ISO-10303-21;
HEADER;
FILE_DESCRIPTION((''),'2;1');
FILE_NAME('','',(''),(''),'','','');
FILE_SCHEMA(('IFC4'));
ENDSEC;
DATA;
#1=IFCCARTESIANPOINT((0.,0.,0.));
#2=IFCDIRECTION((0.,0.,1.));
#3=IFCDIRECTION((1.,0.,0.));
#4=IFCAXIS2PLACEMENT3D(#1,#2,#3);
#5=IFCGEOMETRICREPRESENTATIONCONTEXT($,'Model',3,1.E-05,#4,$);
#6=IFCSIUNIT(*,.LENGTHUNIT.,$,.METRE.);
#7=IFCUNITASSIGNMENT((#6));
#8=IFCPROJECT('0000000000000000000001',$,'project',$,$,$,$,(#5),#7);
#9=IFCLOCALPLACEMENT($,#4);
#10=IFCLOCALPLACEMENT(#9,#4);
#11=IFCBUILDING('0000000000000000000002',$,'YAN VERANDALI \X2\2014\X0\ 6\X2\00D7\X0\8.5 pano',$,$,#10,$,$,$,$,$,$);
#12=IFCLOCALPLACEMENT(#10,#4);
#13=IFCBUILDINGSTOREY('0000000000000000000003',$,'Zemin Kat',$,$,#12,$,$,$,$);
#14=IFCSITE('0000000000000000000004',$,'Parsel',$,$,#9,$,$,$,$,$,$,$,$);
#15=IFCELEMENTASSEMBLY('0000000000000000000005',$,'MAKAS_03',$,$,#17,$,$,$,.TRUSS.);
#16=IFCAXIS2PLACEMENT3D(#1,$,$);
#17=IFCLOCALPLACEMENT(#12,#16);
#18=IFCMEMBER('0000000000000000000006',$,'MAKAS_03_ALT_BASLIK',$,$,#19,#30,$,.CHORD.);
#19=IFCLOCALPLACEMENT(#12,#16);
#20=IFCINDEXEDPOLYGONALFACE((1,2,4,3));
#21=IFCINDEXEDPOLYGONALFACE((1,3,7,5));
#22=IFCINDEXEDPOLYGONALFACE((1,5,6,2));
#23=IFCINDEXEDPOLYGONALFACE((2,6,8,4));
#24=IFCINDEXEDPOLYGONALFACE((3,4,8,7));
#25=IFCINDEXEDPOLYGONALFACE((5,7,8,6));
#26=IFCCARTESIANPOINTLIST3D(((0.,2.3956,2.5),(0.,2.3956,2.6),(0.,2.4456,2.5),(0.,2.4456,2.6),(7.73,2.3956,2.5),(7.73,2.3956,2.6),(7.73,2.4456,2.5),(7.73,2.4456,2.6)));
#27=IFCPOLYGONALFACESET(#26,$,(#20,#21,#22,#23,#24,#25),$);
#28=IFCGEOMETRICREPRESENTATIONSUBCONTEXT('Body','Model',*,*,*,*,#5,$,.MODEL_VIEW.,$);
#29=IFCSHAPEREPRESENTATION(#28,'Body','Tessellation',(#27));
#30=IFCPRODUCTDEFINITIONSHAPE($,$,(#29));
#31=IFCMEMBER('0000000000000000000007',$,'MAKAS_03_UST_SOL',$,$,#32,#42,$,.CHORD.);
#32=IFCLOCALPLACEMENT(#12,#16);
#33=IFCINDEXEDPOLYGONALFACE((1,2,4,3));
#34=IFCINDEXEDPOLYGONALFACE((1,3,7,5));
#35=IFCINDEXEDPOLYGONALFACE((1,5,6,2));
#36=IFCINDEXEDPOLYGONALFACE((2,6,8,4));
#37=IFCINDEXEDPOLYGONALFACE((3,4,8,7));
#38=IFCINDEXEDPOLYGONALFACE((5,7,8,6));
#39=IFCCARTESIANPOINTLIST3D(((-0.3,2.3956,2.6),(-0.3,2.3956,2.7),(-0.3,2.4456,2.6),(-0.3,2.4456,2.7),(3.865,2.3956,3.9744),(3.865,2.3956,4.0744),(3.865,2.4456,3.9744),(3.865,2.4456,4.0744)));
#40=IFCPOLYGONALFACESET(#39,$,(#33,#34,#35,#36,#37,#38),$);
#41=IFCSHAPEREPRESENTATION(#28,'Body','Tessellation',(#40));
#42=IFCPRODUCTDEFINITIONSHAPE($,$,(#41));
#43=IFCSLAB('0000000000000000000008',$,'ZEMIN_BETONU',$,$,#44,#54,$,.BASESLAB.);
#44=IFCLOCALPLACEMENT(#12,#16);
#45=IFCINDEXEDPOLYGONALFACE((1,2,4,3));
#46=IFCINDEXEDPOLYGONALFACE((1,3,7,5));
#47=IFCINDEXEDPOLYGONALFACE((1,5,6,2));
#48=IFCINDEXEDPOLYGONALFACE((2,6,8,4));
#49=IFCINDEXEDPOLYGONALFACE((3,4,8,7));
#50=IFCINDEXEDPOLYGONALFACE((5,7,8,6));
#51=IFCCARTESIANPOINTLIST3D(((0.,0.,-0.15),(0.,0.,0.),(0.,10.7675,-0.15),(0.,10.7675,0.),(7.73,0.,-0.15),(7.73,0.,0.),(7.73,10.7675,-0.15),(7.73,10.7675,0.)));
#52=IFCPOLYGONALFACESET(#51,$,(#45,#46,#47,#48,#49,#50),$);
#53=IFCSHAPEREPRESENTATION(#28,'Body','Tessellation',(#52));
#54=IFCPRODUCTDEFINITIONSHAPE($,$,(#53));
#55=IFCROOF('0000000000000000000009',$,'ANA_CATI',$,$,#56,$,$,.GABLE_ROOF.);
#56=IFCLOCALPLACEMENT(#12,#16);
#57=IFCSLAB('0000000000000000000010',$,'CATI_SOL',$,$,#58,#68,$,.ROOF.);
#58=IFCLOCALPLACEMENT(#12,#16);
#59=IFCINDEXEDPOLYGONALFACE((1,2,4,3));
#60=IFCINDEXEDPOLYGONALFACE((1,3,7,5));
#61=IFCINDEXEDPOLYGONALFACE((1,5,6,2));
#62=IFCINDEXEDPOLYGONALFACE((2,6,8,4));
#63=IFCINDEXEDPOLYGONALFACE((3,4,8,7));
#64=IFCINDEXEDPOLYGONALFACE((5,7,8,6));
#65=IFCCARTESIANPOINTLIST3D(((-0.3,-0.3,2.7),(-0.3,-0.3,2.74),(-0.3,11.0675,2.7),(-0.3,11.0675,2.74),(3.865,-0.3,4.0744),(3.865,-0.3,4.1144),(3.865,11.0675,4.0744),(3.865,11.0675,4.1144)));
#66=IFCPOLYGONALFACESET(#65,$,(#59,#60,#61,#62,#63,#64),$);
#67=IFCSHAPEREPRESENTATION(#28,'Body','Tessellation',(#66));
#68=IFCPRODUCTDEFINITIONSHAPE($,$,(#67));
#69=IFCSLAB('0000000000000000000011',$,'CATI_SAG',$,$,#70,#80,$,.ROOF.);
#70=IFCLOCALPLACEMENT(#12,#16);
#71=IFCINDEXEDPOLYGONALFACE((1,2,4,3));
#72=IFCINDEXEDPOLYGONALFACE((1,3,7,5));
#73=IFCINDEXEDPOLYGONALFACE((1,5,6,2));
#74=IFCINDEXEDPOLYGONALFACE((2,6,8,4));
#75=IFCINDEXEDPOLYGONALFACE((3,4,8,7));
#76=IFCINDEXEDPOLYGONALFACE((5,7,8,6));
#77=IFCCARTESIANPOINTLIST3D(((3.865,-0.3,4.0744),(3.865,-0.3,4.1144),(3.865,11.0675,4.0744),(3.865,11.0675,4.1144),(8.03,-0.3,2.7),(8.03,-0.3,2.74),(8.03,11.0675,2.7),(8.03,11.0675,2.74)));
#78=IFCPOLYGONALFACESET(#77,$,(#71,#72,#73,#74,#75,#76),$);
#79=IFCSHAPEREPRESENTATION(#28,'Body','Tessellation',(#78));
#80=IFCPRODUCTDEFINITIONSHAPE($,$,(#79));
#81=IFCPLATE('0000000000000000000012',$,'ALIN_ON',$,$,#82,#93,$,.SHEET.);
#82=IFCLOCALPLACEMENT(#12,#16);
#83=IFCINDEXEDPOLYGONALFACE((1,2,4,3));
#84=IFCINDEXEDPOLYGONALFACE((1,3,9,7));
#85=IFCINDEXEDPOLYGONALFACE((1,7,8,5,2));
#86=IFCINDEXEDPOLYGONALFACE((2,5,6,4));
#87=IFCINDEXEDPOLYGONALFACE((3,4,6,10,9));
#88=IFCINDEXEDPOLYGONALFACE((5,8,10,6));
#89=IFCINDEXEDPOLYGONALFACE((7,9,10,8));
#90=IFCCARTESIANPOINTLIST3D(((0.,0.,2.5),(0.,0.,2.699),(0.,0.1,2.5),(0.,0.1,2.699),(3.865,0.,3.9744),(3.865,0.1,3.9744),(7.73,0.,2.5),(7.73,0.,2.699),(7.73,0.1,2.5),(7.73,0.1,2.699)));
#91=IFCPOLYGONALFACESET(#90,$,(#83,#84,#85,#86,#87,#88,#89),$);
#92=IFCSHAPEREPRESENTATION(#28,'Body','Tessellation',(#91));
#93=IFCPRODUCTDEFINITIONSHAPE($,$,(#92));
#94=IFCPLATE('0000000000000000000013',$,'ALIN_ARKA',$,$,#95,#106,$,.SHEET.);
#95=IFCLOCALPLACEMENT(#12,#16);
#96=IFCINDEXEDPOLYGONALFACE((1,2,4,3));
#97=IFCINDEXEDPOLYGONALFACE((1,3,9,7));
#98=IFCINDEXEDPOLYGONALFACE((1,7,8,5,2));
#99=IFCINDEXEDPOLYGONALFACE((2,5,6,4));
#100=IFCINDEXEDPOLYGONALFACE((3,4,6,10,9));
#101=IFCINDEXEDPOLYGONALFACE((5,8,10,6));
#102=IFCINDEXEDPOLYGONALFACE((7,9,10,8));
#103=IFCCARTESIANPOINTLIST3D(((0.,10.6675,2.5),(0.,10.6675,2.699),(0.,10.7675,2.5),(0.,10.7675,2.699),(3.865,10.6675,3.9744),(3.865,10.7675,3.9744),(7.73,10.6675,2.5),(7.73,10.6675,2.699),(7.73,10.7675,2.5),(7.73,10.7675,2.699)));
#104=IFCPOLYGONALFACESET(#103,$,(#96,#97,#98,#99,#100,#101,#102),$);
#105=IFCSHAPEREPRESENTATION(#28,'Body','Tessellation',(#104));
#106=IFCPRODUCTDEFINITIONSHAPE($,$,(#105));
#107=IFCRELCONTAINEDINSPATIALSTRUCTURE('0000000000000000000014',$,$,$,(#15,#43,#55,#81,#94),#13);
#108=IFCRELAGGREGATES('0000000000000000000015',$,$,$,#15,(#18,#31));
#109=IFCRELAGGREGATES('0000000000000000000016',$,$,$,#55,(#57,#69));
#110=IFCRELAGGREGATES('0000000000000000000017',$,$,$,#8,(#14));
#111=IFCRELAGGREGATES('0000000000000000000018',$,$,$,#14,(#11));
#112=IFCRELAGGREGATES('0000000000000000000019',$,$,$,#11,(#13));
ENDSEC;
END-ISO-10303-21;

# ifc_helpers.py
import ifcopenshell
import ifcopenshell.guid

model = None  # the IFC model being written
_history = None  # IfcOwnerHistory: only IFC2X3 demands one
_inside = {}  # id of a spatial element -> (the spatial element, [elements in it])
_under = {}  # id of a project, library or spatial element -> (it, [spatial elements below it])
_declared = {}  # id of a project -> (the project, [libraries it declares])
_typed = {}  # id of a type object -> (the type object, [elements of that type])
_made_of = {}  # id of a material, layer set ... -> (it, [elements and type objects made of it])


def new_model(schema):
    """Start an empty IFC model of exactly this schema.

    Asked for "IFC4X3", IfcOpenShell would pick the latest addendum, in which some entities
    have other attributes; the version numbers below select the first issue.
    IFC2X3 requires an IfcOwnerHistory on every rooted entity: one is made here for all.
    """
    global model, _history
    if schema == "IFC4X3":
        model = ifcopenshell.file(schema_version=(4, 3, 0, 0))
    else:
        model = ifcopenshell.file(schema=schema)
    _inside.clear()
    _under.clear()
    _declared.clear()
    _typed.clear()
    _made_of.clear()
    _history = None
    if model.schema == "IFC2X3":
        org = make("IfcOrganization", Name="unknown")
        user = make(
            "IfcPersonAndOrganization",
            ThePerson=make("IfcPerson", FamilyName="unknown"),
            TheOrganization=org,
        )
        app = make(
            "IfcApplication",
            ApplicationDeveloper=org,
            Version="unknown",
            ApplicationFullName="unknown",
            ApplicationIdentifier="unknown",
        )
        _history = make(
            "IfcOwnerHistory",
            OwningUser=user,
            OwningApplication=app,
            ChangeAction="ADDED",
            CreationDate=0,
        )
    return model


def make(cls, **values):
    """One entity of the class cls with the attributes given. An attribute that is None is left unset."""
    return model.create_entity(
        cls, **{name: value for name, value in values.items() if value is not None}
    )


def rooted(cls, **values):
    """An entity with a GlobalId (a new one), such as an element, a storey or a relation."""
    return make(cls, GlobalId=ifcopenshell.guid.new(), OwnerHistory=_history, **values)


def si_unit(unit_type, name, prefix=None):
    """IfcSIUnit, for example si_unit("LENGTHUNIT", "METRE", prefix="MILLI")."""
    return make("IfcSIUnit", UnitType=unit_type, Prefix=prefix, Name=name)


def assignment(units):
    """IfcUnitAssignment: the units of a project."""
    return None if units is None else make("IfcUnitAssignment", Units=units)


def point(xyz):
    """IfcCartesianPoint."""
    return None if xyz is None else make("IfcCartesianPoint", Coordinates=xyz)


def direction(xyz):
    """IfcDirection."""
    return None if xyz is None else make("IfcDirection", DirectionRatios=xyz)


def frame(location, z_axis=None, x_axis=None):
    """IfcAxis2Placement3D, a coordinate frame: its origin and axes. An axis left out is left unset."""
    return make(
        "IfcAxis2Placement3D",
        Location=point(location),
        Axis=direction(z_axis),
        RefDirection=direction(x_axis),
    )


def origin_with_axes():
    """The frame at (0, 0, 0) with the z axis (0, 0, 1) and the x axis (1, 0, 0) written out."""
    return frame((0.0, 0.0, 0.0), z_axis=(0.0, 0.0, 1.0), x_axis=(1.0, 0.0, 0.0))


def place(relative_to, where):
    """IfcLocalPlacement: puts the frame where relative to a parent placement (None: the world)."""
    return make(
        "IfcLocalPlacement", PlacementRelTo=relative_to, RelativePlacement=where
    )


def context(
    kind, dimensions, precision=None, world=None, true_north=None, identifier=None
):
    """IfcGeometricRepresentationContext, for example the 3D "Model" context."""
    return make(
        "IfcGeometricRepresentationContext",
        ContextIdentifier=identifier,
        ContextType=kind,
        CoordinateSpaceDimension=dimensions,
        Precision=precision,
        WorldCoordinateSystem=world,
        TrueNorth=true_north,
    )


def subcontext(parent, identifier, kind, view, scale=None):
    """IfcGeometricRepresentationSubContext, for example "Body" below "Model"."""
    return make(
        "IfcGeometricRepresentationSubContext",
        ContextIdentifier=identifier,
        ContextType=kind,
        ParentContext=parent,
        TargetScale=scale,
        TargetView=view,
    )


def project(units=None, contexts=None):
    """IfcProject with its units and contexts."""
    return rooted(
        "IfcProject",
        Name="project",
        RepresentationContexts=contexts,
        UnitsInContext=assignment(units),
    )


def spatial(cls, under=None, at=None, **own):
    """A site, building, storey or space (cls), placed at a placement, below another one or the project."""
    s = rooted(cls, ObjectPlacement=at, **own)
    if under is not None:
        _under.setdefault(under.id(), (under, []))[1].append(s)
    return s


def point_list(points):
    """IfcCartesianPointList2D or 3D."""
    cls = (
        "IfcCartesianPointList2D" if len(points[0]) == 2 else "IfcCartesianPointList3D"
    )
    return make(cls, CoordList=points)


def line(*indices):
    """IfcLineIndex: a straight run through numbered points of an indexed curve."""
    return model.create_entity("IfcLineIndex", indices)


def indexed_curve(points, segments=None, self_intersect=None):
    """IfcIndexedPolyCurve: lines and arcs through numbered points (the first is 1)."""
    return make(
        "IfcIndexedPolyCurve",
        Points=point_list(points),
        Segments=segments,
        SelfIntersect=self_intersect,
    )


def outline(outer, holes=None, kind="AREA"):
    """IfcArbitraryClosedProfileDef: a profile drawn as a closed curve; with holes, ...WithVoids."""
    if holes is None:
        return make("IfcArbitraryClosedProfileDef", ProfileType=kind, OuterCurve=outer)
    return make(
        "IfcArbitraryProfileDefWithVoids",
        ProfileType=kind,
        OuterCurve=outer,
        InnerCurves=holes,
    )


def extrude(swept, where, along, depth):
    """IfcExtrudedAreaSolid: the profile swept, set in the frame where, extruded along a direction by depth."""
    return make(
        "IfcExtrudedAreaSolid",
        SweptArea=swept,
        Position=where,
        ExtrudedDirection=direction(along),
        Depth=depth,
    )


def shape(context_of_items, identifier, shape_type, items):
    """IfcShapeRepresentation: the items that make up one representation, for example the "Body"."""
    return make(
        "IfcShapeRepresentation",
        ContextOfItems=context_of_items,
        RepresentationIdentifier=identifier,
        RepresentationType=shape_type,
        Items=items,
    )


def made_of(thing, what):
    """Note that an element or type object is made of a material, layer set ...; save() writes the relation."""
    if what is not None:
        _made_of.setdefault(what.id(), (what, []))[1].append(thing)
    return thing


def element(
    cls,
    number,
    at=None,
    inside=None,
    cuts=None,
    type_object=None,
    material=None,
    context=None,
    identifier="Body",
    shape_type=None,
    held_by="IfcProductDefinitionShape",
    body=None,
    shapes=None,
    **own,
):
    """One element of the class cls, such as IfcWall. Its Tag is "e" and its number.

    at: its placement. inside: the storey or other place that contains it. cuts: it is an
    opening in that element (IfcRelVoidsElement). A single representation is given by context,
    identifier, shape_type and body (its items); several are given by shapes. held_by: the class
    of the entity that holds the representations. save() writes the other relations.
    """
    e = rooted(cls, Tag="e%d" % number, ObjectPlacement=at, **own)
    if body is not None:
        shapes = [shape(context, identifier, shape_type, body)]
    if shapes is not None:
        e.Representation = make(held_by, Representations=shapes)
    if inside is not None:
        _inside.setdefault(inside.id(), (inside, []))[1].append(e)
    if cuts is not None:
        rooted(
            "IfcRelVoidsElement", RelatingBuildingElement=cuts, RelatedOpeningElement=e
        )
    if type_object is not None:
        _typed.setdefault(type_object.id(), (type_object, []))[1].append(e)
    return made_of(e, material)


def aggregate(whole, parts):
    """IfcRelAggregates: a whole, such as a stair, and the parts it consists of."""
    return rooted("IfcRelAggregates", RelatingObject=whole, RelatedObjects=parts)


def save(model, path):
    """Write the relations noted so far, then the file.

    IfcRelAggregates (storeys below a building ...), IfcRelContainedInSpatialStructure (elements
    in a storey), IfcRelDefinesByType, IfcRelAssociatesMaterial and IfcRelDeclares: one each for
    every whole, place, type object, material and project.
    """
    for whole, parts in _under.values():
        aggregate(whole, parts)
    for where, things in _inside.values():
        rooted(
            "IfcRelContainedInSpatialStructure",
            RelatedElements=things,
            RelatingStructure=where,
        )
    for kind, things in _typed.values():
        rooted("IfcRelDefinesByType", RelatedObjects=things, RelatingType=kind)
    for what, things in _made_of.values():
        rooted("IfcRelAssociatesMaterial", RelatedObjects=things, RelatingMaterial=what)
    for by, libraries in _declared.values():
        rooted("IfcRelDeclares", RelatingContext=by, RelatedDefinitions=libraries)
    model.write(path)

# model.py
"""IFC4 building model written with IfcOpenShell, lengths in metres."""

from ifc_helpers import new_model, si_unit, frame, origin_with_axes, place, context, subcontext, project, spatial, line, indexed_curve, outline, extrude, element, aggregate, save


model = new_model("IFC4")

# Units and contexts
model_context = context("Model", 3, precision=1e-05, world=origin_with_axes())
body_context = subcontext(model_context, "Body", "Model", "MODEL_VIEW")
ifc_project = project(units=[si_unit("LENGTHUNIT", "METRE")], contexts=[model_context])

# Site, building, storey
site_placement = place(None, origin_with_axes())
site = spatial("IfcSite", under=ifc_project, at=site_placement, Name="Parsel")
building_placement = place(site_placement, origin_with_axes())
building = spatial("IfcBuilding", under=site, at=building_placement, Name="YAN VERANDALI — 6×8.5 pano")
storey_placement = place(building_placement, origin_with_axes())
storey = spatial("IfcBuildingStorey", under=building, at=storey_placement, Name="Zemin Kat")

# Element assembly, members
assembly_1_placement = place(storey_placement, origin_with_axes())
assembly_1 = element("IfcElementAssembly", 1, at=assembly_1_placement, inside=storey, Name="MAKAS_03", PredefinedType="TRUSS")
member_1_placement = place(assembly_1_placement, origin_with_axes())
member_1 = element("IfcMember", 2, at=member_1_placement, Name="MAKAS_03_ALT_BASLIK", PredefinedType="CHORD", context=body_context, shape_type="SweptSolid", body=[
    extrude(outline(indexed_curve([(0.0, 2.5), (7.73, 2.5), (7.73, 2.6), (0.0, 2.6)], segments=[line(1, 2, 3, 4, 1)])), frame((0.0, 2.4456, 0.0), z_axis=(0.0, -1.0, 0.0), x_axis=(1.0, 0.0, 0.0)), (0.0, 0.0, 1.0), 0.05),
])
member_2_placement = place(assembly_1_placement, origin_with_axes())
member_2 = element("IfcMember", 3, at=member_2_placement, Name="MAKAS_03_UST_SOL", PredefinedType="CHORD", context=body_context, shape_type="SweptSolid", body=[
    extrude(outline(indexed_curve([(-0.3, 2.6), (3.865, 3.9745), (3.865, 4.0744), (-0.3, 2.7)], segments=[line(1, 2, 3, 4, 1)])), frame((0.0, 2.4456, 0.0), z_axis=(0.0, -1.0, 0.0), x_axis=(1.0, 0.0, 0.0)), (0.0, 0.0, 1.0), 0.05),
])
aggregate(assembly_1, [member_1, member_2])

# Slab
slab_1_placement = place(storey_placement, origin_with_axes())
element("IfcSlab", 4, at=slab_1_placement, inside=storey, Name="ZEMIN_BETONU", PredefinedType="BASESLAB", context=body_context, shape_type="SweptSolid", body=[
    extrude(outline(indexed_curve([(0.0, 0.0), (7.73, 0.0), (7.73, 10.7675), (0.0, 10.7675)], segments=[line(1, 2, 3, 4, 1)])), frame((0.0, 0.0, -0.15), z_axis=(0.0, 0.0, 1.0), x_axis=(1.0, 0.0, 0.0)), (0.0, 0.0, 1.0), 0.15),
])

# Roof, slabs
roof_placement = place(storey_placement, origin_with_axes())
roof = element("IfcRoof", 5, at=roof_placement, inside=storey, Name="ANA_CATI", PredefinedType="GABLE_ROOF")
slab_2_placement = place(roof_placement, origin_with_axes())
slab_2 = element("IfcSlab", 6, at=slab_2_placement, Name="CATI_SOL", PredefinedType="ROOF", context=body_context, shape_type="SweptSolid", body=[
    extrude(outline(indexed_curve([(-0.3, 2.7), (3.865, 4.0744), (3.865, 4.1144), (-0.3, 2.74)], segments=[line(1, 2, 3, 4, 1)])), frame((0.0, 11.0675, 0.0), z_axis=(0.0, -1.0, 0.0), x_axis=(1.0, 0.0, 0.0)), (0.0, 0.0, 1.0), 11.3675),
])
slab_3_placement = place(roof_placement, origin_with_axes())
slab_3 = element("IfcSlab", 7, at=slab_3_placement, Name="CATI_SAG", PredefinedType="ROOF", context=body_context, shape_type="SweptSolid", body=[
    extrude(outline(indexed_curve([(3.865, 4.0744), (8.03, 2.7), (8.03, 2.74), (3.865, 4.1144)], segments=[line(1, 2, 3, 4, 1)])), frame((0.0, 11.0675, 0.0), z_axis=(0.0, -1.0, 0.0), x_axis=(1.0, 0.0, 0.0)), (0.0, 0.0, 1.0), 11.3675),
])
aggregate(roof, [slab_2, slab_3])

# Plates
plate_1_placement = place(storey_placement, origin_with_axes())
element("IfcPlate", 8, at=plate_1_placement, inside=storey, Name="ALIN_ON", PredefinedType="SHEET", context=body_context, shape_type="SweptSolid", body=[
    extrude(outline(indexed_curve([(0.0, 2.5), (7.73, 2.5), (7.73, 2.699), (3.865, 3.9745), (0.0, 2.699)], segments=[line(1, 2, 3, 4, 5, 1)])), frame((0.0, 0.1, 0.0), z_axis=(0.0, -1.0, 0.0), x_axis=(1.0, 0.0, 0.0)), (0.0, 0.0, 1.0), 0.1),
])
plate_2_placement = place(storey_placement, origin_with_axes())
element("IfcPlate", 9, at=plate_2_placement, inside=storey, Name="ALIN_ARKA", PredefinedType="SHEET", context=body_context, shape_type="SweptSolid", body=[
    extrude(outline(indexed_curve([(0.0, 2.5), (7.73, 2.5), (7.73, 2.699), (3.865, 3.9745), (0.0, 2.699)], segments=[line(1, 2, 3, 4, 5, 1)])), frame((0.0, 10.7675, 0.0), z_axis=(0.0, -1.0, 0.0), x_axis=(1.0, 0.0, 0.0)), (0.0, 0.0, 1.0), 0.1),
])

save(model, "model.ifc")
